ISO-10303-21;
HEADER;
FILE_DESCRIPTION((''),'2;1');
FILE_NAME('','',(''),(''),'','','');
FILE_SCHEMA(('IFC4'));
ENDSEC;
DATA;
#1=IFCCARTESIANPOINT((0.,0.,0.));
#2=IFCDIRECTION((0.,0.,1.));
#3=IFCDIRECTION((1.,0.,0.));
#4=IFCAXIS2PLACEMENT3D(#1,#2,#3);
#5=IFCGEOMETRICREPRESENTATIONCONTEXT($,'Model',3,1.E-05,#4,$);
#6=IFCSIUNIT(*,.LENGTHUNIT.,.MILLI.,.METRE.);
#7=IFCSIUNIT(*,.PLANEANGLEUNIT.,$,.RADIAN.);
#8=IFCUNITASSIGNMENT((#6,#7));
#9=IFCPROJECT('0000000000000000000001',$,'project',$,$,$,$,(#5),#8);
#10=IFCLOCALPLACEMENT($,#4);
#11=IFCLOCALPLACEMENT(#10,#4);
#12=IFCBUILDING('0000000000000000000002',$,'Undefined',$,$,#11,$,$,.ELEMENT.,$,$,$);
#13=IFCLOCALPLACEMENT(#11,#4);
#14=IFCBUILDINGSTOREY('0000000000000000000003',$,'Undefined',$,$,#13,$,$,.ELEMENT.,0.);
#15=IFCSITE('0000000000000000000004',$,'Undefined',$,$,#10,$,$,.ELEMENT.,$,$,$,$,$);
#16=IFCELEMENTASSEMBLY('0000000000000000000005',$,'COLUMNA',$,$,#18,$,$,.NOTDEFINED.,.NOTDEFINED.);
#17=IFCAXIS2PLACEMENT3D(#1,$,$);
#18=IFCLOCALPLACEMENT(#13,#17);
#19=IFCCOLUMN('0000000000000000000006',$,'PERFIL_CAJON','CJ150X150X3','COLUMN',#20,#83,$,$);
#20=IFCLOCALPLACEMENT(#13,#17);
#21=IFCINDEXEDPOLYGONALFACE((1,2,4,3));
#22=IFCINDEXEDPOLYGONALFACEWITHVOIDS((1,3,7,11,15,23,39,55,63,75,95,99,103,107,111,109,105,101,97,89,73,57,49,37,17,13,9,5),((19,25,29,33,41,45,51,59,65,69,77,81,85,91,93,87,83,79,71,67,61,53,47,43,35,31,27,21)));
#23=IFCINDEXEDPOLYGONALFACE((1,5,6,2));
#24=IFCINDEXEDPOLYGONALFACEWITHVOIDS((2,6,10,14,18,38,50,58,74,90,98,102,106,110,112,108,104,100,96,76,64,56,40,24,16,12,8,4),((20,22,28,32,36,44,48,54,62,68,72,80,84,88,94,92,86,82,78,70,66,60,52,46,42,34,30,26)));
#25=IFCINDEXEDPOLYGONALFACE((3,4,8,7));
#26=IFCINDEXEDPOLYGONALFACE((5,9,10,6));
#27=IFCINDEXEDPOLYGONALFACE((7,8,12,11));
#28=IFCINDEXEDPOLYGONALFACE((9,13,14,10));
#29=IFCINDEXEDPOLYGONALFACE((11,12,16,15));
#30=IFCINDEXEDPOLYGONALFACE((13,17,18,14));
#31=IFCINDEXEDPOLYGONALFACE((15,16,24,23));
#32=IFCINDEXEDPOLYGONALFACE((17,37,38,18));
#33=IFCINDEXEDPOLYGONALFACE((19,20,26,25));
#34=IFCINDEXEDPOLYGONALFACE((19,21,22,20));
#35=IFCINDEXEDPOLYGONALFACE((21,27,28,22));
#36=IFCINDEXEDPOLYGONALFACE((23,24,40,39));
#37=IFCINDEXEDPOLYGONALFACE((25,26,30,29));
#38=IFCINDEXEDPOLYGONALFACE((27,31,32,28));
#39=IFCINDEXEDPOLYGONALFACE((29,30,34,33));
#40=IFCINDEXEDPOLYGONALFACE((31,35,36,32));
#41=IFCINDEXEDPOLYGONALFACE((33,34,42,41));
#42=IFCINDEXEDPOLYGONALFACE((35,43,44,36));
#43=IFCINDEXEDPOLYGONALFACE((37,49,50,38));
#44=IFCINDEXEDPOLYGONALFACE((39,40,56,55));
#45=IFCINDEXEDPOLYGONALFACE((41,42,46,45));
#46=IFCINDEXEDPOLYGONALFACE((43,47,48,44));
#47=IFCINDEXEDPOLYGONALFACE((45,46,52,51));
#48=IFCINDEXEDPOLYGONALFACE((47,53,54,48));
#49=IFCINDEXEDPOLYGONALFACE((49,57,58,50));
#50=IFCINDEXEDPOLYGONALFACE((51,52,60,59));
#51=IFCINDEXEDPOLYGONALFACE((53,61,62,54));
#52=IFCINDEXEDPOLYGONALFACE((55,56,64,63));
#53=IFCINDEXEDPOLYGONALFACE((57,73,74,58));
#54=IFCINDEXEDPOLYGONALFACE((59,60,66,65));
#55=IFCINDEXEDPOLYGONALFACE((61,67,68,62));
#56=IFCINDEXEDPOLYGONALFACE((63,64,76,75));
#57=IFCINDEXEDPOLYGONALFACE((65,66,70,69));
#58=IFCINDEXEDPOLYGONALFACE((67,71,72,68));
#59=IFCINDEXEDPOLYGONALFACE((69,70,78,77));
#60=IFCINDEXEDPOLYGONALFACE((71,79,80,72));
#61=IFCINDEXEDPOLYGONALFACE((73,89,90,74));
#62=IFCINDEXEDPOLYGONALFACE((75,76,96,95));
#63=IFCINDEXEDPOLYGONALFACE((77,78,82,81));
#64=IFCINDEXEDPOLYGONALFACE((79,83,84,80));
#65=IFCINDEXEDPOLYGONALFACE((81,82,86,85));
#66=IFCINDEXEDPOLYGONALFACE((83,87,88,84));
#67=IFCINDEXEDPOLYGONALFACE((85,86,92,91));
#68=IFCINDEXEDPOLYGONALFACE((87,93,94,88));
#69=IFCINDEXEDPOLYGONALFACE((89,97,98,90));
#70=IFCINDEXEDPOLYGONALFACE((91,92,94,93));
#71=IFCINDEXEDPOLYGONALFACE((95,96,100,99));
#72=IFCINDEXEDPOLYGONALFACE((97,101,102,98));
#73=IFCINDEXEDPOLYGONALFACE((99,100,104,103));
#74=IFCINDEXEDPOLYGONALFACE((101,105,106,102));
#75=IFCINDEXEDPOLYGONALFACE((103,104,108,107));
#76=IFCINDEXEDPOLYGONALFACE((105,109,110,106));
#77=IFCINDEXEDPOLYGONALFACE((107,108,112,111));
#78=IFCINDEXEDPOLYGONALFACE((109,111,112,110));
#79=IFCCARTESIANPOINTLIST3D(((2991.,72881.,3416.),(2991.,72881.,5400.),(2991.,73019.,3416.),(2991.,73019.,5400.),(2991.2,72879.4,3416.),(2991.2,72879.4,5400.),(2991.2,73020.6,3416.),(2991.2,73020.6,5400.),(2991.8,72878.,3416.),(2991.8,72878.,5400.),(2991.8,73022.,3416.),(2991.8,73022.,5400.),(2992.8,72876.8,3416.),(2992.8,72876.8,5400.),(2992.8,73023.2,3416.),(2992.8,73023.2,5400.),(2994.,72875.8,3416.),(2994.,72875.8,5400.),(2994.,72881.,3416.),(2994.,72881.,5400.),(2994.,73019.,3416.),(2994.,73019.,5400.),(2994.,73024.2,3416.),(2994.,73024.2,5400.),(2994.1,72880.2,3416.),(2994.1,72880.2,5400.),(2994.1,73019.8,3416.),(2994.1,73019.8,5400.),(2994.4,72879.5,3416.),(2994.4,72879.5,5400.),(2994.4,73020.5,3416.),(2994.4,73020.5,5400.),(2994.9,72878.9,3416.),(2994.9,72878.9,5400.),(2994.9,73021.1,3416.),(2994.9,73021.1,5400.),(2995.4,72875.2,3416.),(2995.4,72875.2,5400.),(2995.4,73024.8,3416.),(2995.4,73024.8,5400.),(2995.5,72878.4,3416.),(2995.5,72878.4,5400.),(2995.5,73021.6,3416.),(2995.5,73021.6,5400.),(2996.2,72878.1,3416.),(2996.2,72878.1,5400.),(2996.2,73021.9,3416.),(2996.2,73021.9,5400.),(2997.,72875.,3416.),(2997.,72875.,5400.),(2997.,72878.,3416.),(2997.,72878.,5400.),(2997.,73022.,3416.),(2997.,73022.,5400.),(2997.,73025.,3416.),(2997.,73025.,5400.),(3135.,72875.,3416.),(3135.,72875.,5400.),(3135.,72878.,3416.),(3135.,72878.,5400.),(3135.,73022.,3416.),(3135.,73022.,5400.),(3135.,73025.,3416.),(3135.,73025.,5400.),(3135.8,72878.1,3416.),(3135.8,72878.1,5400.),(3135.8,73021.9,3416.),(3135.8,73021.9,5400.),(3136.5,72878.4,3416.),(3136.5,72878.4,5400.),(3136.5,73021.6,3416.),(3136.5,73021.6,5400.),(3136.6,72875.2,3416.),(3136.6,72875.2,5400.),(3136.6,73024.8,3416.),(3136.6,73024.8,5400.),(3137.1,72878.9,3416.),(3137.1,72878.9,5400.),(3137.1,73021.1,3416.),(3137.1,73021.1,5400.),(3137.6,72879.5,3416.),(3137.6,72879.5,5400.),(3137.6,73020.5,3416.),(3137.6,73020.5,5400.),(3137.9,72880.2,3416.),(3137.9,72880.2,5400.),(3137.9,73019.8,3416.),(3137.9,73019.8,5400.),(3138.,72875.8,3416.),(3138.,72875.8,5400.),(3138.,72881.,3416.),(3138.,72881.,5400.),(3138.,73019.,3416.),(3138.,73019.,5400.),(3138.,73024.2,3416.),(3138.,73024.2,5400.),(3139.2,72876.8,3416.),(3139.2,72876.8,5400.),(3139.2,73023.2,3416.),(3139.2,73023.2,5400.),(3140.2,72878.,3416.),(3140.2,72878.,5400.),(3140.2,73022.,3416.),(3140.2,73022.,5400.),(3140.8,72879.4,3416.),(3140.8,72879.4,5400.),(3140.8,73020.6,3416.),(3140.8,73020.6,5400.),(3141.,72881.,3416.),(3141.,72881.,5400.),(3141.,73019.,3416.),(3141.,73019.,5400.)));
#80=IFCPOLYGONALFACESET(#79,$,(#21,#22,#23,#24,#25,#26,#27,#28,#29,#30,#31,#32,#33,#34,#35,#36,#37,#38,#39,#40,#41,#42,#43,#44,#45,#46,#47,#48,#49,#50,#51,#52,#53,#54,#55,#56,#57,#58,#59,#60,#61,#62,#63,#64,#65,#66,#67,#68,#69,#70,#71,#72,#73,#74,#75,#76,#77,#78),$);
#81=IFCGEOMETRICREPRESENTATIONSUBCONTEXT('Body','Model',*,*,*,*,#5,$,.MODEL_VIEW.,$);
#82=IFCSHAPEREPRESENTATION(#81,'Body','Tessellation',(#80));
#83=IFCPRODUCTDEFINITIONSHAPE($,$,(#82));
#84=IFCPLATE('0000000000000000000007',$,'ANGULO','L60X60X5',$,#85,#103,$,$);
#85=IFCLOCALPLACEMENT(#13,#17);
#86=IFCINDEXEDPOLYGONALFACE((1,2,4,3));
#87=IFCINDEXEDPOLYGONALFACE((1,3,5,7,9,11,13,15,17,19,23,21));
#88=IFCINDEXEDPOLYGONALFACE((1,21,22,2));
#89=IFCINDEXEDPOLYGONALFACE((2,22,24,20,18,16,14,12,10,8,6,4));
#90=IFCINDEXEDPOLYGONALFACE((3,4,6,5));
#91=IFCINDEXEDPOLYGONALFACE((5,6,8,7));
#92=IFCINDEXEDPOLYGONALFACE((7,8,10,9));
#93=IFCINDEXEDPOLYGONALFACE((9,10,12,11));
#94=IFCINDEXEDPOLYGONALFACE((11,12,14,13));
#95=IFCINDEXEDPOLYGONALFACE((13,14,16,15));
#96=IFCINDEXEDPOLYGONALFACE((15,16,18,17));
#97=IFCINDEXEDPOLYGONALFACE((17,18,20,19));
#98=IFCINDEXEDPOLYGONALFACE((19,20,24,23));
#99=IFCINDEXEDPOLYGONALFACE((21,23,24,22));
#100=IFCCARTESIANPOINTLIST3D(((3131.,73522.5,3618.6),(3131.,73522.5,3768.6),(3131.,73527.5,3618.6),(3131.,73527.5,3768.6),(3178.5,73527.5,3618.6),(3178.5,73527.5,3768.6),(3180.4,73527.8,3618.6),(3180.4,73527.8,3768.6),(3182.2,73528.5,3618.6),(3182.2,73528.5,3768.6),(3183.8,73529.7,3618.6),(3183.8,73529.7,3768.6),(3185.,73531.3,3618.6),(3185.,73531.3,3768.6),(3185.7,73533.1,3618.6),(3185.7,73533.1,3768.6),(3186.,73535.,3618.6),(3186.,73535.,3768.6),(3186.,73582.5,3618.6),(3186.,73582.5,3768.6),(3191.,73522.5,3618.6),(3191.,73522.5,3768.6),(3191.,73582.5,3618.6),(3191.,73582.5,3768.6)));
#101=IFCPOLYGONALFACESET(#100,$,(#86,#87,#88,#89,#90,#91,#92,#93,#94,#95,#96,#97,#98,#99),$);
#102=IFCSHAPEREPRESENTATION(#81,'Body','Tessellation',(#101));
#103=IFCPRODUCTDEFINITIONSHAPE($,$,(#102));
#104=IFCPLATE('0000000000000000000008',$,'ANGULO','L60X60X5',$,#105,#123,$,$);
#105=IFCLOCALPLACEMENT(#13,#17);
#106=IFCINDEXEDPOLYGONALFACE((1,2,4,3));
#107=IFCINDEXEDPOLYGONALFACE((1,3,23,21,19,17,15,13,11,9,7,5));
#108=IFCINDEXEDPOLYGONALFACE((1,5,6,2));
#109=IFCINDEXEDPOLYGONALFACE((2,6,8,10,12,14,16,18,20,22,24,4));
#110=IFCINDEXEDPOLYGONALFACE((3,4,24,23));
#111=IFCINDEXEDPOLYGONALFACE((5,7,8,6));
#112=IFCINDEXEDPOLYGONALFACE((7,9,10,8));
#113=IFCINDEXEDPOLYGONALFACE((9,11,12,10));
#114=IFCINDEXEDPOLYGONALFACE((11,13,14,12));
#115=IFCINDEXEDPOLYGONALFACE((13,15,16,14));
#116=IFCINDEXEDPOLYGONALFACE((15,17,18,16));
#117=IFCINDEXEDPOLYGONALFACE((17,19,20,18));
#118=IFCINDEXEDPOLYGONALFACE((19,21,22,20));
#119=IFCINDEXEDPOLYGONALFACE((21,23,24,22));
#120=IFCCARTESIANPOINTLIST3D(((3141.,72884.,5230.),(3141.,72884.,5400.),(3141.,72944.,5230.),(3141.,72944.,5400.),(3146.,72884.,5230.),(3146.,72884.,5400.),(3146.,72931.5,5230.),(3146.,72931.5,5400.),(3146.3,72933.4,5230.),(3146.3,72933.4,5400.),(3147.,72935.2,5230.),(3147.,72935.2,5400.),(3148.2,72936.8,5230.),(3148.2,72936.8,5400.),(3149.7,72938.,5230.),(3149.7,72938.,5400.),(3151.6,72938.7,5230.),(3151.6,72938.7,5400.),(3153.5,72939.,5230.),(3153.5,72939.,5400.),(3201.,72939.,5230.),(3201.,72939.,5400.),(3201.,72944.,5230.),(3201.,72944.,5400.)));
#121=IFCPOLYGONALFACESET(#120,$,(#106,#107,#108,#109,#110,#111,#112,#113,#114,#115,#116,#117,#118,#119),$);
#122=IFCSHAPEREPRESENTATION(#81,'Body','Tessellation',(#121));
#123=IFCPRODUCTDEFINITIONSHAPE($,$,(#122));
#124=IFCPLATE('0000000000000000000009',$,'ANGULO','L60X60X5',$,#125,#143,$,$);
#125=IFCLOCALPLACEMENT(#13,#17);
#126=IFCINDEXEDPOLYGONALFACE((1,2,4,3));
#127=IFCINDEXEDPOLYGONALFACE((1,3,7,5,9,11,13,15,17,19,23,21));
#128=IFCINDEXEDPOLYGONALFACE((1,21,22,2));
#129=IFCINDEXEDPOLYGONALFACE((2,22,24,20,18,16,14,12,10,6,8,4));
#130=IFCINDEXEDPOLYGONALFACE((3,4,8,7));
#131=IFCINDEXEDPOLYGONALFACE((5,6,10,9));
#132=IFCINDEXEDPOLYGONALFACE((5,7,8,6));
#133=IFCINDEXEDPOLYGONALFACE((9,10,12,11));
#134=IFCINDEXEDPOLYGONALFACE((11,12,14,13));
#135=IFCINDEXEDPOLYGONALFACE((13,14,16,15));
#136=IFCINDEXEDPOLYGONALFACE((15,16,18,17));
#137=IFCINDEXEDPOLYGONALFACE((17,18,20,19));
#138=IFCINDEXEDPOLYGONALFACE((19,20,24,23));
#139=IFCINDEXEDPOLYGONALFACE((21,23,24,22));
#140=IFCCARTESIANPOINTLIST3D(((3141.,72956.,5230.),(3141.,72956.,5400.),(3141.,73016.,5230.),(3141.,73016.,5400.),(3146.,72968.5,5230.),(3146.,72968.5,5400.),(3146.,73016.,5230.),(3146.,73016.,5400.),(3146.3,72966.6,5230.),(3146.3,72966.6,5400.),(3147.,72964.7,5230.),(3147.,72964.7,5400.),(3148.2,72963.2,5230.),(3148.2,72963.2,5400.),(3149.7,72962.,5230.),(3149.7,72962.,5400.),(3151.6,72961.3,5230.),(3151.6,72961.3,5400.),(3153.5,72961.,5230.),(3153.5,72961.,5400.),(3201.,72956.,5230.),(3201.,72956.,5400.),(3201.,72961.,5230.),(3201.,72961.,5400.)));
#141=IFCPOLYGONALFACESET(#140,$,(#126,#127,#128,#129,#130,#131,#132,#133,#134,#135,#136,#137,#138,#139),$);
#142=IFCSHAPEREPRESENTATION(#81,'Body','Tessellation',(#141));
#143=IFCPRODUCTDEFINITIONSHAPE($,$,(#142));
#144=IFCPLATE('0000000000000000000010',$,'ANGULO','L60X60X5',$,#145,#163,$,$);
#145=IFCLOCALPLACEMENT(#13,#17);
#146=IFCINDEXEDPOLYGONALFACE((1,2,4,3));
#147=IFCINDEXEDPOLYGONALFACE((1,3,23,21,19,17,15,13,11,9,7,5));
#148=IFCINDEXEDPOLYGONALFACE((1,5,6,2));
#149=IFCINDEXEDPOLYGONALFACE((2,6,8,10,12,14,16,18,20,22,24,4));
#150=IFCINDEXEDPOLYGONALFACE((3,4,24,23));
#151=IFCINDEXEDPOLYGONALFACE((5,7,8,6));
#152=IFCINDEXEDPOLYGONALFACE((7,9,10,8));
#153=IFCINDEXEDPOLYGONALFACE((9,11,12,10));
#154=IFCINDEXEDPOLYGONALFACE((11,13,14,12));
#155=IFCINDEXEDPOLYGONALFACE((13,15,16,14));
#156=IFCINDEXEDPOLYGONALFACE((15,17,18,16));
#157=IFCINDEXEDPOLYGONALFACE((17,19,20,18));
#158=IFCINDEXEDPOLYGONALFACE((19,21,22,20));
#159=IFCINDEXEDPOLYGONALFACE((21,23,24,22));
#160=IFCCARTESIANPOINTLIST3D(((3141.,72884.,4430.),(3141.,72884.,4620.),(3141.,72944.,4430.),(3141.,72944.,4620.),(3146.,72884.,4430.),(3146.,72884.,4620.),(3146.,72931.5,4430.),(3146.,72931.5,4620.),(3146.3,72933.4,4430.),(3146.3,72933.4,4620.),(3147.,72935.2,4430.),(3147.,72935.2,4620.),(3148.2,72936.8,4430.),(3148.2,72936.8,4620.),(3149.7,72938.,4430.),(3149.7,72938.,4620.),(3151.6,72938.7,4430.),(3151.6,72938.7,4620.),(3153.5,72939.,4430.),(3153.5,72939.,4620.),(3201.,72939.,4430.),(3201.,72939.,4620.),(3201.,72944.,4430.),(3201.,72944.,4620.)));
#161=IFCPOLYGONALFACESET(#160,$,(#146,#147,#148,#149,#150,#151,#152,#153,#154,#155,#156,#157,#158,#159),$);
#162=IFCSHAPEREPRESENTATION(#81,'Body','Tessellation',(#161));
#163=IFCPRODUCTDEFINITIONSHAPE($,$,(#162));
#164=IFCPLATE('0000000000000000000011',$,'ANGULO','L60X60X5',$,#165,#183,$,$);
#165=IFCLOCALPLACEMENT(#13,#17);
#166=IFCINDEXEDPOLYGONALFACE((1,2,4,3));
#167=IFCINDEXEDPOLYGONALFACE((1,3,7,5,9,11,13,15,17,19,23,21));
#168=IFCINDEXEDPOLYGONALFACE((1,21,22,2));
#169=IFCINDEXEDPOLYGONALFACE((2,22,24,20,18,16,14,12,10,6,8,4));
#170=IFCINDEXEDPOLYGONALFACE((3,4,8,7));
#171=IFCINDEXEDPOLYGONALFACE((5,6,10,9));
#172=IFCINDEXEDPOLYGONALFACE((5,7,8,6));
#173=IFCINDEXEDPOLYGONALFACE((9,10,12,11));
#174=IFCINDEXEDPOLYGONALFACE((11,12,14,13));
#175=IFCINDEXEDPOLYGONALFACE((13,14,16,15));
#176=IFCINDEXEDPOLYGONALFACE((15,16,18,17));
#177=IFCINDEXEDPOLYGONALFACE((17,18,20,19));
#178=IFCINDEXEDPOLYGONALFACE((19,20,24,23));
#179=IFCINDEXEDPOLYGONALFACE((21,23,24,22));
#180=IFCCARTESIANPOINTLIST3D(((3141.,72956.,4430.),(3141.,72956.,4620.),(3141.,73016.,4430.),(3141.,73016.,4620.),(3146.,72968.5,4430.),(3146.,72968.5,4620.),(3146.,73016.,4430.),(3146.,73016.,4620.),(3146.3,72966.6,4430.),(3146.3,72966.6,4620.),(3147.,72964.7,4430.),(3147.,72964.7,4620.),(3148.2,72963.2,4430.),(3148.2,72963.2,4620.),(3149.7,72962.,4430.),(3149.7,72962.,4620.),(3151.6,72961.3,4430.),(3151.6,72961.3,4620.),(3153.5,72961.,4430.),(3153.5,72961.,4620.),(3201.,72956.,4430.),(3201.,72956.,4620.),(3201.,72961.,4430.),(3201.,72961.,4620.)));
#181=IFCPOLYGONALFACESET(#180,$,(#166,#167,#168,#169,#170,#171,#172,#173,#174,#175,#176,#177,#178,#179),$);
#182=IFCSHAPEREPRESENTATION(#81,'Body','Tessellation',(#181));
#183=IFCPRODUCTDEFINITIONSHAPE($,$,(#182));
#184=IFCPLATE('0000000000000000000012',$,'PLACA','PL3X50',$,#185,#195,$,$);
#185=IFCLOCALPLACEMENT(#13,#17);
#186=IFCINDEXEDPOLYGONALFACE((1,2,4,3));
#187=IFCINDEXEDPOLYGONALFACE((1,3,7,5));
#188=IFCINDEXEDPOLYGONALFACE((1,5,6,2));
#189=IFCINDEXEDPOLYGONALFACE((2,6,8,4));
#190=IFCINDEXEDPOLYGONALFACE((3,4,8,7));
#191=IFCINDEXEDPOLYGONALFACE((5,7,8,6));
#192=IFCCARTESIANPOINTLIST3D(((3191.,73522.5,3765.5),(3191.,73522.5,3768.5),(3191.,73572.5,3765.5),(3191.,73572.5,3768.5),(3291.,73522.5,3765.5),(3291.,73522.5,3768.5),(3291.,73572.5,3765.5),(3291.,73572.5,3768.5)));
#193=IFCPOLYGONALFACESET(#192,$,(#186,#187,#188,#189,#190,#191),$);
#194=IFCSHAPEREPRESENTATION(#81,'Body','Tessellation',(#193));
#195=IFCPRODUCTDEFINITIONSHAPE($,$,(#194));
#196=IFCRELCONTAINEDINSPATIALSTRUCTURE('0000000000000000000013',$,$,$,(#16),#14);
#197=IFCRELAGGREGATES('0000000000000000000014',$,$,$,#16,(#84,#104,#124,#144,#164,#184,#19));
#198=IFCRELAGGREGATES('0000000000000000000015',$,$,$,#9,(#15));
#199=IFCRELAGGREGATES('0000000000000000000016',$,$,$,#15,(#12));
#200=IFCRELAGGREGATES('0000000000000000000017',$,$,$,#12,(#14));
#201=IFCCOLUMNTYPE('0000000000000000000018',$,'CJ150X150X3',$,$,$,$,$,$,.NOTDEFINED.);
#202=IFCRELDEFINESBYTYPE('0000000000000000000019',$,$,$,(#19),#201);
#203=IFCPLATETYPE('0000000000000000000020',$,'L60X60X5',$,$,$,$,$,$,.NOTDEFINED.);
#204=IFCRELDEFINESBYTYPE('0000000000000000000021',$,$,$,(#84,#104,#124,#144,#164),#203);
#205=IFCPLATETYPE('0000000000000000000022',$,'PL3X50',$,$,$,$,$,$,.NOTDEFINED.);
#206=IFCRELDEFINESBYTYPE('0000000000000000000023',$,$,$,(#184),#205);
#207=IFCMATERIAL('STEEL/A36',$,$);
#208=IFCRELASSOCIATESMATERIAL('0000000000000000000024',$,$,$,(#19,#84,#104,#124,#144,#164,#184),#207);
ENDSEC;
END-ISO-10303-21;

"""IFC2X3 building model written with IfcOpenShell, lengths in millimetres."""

from ifc_helpers import new_model, si_unit, frame, origin_with_axes, origin_2d_with_axis, place, context, subcontext, project, spatial, polyline, hollow_rectangle, l_section, outline, extrude, material, type_object, element, aggregate, save


model = new_model("IFC2X3")

# Units and contexts
model_context = context("Model", 3, precision=1e-05, world=origin_with_axes())
body_context = subcontext(model_context, "Body", "Model", "MODEL_VIEW")
ifc_project = project(units=[si_unit("LENGTHUNIT", "METRE", prefix="MILLI"), si_unit("PLANEANGLEUNIT", "RADIAN")], contexts=[model_context])

# Site, building, storey
site_placement = place(None, origin_with_axes())
site = spatial("IfcSite", under=ifc_project, at=site_placement, Name="Undefined", CompositionType="ELEMENT")
building_placement = place(site_placement, origin_with_axes())
building = spatial("IfcBuilding", under=site, at=building_placement, Name="Undefined", CompositionType="ELEMENT")
storey_placement = place(building_placement, origin_with_axes())
storey = spatial("IfcBuildingStorey", under=building, at=storey_placement, Name="Undefined", CompositionType="ELEMENT", Elevation=0.0)

# Element assembly, column
assembly_1_placement = place(storey_placement, origin_with_axes())
assembly_1 = element("IfcElementAssembly", 1, at=assembly_1_placement, inside=storey, Name="COLUMNA", AssemblyPlace="NOTDEFINED", PredefinedType="NOTDEFINED")
ifc_material_1 = material(Name="STEEL/A36")
column_type = type_object("IfcColumnType", Name="CJ150X150X3", PredefinedType="NOTDEFINED")
column_placement = place(assembly_1_placement, frame((3066.0, 72950.0, 3416.0), z_axis=(0.0, 0.0, 1.0), x_axis=(-1.0, 0.0, 0.0)))
column = element("IfcColumn", 2, at=column_placement, type_object=column_type, material=ifc_material_1, Name="PERFIL_CAJON", Description="CJ150X150X3", ObjectType="COLUMN", context=body_context, shape_type="SweptSolid", body=[
    extrude(hollow_rectangle(XDim=150.0, YDim=150.0, WallThickness=3.0, InnerFilletRadius=3.0, OuterFilletRadius=6.0, at=origin_2d_with_axis()), frame((0.0, 0.0, 1984.0), z_axis=(0.0, 0.0, -1.0), x_axis=(0.0, 1.0, 0.0)), (0.0, 0.0, 1.0), 1984.0),
])

# Plates
plate_type_1 = type_object("IfcPlateType", Name="L60X60X5", PredefinedType="NOTDEFINED")
plate_1_placement = place(assembly_1_placement, frame((3161.0, 73552.5, 3618.6), z_axis=(0.0, 1.0, 0.0), x_axis=(0.0, 0.0, 1.0)))
plate_1 = element("IfcPlate", 3, at=plate_1_placement, type_object=plate_type_1, material=ifc_material_1, Name="ANGULO", Description="L60X60X5", context=body_context, shape_type="SweptSolid", body=[
    extrude(l_section(Depth=60.0, Width=60.0, Thickness=5.0, FilletRadius=7.5, at=origin_2d_with_axis()), frame((150.0, 0.0, 0.0), z_axis=(-1.0, 0.0, 0.0), x_axis=(0.0, -1.0, 0.0)), (0.0, 0.0, 1.0), 150.0),
])
plate_2_placement = place(assembly_1_placement, frame((3171.0, 72914.0, 5230.0), z_axis=(0.0, -1.0, 0.0), x_axis=(0.0, 0.0, 1.0)))
plate_2 = element("IfcPlate", 4, at=plate_2_placement, type_object=plate_type_1, material=ifc_material_1, Name="ANGULO", Description="L60X60X5", context=body_context, shape_type="SweptSolid", body=[
    extrude(l_section(Depth=60.0, Width=60.0, Thickness=5.0, FilletRadius=7.5, at=origin_2d_with_axis()), frame((170.0, 0.0, 0.0), z_axis=(-1.0, 0.0, 0.0), x_axis=(0.0, -1.0, 0.0)), (0.0, 0.0, 1.0), 170.0),
])
plate_3_placement = place(assembly_1_placement, frame((3171.0, 72986.0, 5400.0), z_axis=(0.0, 1.0, 0.0), x_axis=(0.0, 0.0, -1.0)))
plate_3 = element("IfcPlate", 5, at=plate_3_placement, type_object=plate_type_1, material=ifc_material_1, Name="ANGULO", Description="L60X60X5", context=body_context, shape_type="SweptSolid", body=[
    extrude(l_section(Depth=60.0, Width=60.0, Thickness=5.0, FilletRadius=7.5, at=origin_2d_with_axis()), frame((170.0, 0.0, 0.0), z_axis=(-1.0, 0.0, 0.0), x_axis=(0.0, -1.0, 0.0)), (0.0, 0.0, 1.0), 170.0),
])
plate_4_placement = place(assembly_1_placement, frame((3171.0, 72914.0, 4430.0), z_axis=(0.0, -1.0, 0.0), x_axis=(0.0, 0.0, 1.0)))
plate_4 = element("IfcPlate", 6, at=plate_4_placement, type_object=plate_type_1, material=ifc_material_1, Name="ANGULO", Description="L60X60X5", context=body_context, shape_type="SweptSolid", body=[
    extrude(l_section(Depth=60.0, Width=60.0, Thickness=5.0, FilletRadius=7.5, at=origin_2d_with_axis()), frame((190.0, 0.0, 0.0), z_axis=(-1.0, 0.0, 0.0), x_axis=(0.0, -1.0, 0.0)), (0.0, 0.0, 1.0), 190.0),
])
plate_5_placement = place(assembly_1_placement, frame((3171.0, 72986.0, 4620.0), z_axis=(0.0, 1.0, 0.0), x_axis=(0.0, 0.0, -1.0)))
plate_5 = element("IfcPlate", 7, at=plate_5_placement, type_object=plate_type_1, material=ifc_material_1, Name="ANGULO", Description="L60X60X5", context=body_context, shape_type="SweptSolid", body=[
    extrude(l_section(Depth=60.0, Width=60.0, Thickness=5.0, FilletRadius=7.5, at=origin_2d_with_axis()), frame((190.0, 0.0, 0.0), z_axis=(-1.0, 0.0, 0.0), x_axis=(0.0, -1.0, 0.0)), (0.0, 0.0, 1.0), 190.0),
])
plate_type_2 = type_object("IfcPlateType", Name="PL3X50", PredefinedType="NOTDEFINED")
plate_6_placement = place(assembly_1_placement, frame((3191.0, 73522.5, 3767.0), z_axis=(0.0, 0.0, -1.0), x_axis=(0.0, 1.0, 0.0)))
plate_6 = element("IfcPlate", 8, at=plate_6_placement, type_object=plate_type_2, material=ifc_material_1, Name="PLACA", Description="PL3X50", context=body_context, shape_type="SweptSolid", body=[
    extrude(outline(polyline([(0.0, 0.0), (50.0, 0.0), (50.0, 100.0), (0.0, 100.0), (0.0, 0.0)])), frame((0.0, 0.0, -1.5), z_axis=(0.0, 0.0, 1.0), x_axis=(1.0, 0.0, 0.0)), (0.0, 0.0, 1.0), 3.0),
])

aggregate(assembly_1, [plate_1, plate_2, plate_3, plate_4, plate_5, plate_6, column])

save(model, "model.ifc")
